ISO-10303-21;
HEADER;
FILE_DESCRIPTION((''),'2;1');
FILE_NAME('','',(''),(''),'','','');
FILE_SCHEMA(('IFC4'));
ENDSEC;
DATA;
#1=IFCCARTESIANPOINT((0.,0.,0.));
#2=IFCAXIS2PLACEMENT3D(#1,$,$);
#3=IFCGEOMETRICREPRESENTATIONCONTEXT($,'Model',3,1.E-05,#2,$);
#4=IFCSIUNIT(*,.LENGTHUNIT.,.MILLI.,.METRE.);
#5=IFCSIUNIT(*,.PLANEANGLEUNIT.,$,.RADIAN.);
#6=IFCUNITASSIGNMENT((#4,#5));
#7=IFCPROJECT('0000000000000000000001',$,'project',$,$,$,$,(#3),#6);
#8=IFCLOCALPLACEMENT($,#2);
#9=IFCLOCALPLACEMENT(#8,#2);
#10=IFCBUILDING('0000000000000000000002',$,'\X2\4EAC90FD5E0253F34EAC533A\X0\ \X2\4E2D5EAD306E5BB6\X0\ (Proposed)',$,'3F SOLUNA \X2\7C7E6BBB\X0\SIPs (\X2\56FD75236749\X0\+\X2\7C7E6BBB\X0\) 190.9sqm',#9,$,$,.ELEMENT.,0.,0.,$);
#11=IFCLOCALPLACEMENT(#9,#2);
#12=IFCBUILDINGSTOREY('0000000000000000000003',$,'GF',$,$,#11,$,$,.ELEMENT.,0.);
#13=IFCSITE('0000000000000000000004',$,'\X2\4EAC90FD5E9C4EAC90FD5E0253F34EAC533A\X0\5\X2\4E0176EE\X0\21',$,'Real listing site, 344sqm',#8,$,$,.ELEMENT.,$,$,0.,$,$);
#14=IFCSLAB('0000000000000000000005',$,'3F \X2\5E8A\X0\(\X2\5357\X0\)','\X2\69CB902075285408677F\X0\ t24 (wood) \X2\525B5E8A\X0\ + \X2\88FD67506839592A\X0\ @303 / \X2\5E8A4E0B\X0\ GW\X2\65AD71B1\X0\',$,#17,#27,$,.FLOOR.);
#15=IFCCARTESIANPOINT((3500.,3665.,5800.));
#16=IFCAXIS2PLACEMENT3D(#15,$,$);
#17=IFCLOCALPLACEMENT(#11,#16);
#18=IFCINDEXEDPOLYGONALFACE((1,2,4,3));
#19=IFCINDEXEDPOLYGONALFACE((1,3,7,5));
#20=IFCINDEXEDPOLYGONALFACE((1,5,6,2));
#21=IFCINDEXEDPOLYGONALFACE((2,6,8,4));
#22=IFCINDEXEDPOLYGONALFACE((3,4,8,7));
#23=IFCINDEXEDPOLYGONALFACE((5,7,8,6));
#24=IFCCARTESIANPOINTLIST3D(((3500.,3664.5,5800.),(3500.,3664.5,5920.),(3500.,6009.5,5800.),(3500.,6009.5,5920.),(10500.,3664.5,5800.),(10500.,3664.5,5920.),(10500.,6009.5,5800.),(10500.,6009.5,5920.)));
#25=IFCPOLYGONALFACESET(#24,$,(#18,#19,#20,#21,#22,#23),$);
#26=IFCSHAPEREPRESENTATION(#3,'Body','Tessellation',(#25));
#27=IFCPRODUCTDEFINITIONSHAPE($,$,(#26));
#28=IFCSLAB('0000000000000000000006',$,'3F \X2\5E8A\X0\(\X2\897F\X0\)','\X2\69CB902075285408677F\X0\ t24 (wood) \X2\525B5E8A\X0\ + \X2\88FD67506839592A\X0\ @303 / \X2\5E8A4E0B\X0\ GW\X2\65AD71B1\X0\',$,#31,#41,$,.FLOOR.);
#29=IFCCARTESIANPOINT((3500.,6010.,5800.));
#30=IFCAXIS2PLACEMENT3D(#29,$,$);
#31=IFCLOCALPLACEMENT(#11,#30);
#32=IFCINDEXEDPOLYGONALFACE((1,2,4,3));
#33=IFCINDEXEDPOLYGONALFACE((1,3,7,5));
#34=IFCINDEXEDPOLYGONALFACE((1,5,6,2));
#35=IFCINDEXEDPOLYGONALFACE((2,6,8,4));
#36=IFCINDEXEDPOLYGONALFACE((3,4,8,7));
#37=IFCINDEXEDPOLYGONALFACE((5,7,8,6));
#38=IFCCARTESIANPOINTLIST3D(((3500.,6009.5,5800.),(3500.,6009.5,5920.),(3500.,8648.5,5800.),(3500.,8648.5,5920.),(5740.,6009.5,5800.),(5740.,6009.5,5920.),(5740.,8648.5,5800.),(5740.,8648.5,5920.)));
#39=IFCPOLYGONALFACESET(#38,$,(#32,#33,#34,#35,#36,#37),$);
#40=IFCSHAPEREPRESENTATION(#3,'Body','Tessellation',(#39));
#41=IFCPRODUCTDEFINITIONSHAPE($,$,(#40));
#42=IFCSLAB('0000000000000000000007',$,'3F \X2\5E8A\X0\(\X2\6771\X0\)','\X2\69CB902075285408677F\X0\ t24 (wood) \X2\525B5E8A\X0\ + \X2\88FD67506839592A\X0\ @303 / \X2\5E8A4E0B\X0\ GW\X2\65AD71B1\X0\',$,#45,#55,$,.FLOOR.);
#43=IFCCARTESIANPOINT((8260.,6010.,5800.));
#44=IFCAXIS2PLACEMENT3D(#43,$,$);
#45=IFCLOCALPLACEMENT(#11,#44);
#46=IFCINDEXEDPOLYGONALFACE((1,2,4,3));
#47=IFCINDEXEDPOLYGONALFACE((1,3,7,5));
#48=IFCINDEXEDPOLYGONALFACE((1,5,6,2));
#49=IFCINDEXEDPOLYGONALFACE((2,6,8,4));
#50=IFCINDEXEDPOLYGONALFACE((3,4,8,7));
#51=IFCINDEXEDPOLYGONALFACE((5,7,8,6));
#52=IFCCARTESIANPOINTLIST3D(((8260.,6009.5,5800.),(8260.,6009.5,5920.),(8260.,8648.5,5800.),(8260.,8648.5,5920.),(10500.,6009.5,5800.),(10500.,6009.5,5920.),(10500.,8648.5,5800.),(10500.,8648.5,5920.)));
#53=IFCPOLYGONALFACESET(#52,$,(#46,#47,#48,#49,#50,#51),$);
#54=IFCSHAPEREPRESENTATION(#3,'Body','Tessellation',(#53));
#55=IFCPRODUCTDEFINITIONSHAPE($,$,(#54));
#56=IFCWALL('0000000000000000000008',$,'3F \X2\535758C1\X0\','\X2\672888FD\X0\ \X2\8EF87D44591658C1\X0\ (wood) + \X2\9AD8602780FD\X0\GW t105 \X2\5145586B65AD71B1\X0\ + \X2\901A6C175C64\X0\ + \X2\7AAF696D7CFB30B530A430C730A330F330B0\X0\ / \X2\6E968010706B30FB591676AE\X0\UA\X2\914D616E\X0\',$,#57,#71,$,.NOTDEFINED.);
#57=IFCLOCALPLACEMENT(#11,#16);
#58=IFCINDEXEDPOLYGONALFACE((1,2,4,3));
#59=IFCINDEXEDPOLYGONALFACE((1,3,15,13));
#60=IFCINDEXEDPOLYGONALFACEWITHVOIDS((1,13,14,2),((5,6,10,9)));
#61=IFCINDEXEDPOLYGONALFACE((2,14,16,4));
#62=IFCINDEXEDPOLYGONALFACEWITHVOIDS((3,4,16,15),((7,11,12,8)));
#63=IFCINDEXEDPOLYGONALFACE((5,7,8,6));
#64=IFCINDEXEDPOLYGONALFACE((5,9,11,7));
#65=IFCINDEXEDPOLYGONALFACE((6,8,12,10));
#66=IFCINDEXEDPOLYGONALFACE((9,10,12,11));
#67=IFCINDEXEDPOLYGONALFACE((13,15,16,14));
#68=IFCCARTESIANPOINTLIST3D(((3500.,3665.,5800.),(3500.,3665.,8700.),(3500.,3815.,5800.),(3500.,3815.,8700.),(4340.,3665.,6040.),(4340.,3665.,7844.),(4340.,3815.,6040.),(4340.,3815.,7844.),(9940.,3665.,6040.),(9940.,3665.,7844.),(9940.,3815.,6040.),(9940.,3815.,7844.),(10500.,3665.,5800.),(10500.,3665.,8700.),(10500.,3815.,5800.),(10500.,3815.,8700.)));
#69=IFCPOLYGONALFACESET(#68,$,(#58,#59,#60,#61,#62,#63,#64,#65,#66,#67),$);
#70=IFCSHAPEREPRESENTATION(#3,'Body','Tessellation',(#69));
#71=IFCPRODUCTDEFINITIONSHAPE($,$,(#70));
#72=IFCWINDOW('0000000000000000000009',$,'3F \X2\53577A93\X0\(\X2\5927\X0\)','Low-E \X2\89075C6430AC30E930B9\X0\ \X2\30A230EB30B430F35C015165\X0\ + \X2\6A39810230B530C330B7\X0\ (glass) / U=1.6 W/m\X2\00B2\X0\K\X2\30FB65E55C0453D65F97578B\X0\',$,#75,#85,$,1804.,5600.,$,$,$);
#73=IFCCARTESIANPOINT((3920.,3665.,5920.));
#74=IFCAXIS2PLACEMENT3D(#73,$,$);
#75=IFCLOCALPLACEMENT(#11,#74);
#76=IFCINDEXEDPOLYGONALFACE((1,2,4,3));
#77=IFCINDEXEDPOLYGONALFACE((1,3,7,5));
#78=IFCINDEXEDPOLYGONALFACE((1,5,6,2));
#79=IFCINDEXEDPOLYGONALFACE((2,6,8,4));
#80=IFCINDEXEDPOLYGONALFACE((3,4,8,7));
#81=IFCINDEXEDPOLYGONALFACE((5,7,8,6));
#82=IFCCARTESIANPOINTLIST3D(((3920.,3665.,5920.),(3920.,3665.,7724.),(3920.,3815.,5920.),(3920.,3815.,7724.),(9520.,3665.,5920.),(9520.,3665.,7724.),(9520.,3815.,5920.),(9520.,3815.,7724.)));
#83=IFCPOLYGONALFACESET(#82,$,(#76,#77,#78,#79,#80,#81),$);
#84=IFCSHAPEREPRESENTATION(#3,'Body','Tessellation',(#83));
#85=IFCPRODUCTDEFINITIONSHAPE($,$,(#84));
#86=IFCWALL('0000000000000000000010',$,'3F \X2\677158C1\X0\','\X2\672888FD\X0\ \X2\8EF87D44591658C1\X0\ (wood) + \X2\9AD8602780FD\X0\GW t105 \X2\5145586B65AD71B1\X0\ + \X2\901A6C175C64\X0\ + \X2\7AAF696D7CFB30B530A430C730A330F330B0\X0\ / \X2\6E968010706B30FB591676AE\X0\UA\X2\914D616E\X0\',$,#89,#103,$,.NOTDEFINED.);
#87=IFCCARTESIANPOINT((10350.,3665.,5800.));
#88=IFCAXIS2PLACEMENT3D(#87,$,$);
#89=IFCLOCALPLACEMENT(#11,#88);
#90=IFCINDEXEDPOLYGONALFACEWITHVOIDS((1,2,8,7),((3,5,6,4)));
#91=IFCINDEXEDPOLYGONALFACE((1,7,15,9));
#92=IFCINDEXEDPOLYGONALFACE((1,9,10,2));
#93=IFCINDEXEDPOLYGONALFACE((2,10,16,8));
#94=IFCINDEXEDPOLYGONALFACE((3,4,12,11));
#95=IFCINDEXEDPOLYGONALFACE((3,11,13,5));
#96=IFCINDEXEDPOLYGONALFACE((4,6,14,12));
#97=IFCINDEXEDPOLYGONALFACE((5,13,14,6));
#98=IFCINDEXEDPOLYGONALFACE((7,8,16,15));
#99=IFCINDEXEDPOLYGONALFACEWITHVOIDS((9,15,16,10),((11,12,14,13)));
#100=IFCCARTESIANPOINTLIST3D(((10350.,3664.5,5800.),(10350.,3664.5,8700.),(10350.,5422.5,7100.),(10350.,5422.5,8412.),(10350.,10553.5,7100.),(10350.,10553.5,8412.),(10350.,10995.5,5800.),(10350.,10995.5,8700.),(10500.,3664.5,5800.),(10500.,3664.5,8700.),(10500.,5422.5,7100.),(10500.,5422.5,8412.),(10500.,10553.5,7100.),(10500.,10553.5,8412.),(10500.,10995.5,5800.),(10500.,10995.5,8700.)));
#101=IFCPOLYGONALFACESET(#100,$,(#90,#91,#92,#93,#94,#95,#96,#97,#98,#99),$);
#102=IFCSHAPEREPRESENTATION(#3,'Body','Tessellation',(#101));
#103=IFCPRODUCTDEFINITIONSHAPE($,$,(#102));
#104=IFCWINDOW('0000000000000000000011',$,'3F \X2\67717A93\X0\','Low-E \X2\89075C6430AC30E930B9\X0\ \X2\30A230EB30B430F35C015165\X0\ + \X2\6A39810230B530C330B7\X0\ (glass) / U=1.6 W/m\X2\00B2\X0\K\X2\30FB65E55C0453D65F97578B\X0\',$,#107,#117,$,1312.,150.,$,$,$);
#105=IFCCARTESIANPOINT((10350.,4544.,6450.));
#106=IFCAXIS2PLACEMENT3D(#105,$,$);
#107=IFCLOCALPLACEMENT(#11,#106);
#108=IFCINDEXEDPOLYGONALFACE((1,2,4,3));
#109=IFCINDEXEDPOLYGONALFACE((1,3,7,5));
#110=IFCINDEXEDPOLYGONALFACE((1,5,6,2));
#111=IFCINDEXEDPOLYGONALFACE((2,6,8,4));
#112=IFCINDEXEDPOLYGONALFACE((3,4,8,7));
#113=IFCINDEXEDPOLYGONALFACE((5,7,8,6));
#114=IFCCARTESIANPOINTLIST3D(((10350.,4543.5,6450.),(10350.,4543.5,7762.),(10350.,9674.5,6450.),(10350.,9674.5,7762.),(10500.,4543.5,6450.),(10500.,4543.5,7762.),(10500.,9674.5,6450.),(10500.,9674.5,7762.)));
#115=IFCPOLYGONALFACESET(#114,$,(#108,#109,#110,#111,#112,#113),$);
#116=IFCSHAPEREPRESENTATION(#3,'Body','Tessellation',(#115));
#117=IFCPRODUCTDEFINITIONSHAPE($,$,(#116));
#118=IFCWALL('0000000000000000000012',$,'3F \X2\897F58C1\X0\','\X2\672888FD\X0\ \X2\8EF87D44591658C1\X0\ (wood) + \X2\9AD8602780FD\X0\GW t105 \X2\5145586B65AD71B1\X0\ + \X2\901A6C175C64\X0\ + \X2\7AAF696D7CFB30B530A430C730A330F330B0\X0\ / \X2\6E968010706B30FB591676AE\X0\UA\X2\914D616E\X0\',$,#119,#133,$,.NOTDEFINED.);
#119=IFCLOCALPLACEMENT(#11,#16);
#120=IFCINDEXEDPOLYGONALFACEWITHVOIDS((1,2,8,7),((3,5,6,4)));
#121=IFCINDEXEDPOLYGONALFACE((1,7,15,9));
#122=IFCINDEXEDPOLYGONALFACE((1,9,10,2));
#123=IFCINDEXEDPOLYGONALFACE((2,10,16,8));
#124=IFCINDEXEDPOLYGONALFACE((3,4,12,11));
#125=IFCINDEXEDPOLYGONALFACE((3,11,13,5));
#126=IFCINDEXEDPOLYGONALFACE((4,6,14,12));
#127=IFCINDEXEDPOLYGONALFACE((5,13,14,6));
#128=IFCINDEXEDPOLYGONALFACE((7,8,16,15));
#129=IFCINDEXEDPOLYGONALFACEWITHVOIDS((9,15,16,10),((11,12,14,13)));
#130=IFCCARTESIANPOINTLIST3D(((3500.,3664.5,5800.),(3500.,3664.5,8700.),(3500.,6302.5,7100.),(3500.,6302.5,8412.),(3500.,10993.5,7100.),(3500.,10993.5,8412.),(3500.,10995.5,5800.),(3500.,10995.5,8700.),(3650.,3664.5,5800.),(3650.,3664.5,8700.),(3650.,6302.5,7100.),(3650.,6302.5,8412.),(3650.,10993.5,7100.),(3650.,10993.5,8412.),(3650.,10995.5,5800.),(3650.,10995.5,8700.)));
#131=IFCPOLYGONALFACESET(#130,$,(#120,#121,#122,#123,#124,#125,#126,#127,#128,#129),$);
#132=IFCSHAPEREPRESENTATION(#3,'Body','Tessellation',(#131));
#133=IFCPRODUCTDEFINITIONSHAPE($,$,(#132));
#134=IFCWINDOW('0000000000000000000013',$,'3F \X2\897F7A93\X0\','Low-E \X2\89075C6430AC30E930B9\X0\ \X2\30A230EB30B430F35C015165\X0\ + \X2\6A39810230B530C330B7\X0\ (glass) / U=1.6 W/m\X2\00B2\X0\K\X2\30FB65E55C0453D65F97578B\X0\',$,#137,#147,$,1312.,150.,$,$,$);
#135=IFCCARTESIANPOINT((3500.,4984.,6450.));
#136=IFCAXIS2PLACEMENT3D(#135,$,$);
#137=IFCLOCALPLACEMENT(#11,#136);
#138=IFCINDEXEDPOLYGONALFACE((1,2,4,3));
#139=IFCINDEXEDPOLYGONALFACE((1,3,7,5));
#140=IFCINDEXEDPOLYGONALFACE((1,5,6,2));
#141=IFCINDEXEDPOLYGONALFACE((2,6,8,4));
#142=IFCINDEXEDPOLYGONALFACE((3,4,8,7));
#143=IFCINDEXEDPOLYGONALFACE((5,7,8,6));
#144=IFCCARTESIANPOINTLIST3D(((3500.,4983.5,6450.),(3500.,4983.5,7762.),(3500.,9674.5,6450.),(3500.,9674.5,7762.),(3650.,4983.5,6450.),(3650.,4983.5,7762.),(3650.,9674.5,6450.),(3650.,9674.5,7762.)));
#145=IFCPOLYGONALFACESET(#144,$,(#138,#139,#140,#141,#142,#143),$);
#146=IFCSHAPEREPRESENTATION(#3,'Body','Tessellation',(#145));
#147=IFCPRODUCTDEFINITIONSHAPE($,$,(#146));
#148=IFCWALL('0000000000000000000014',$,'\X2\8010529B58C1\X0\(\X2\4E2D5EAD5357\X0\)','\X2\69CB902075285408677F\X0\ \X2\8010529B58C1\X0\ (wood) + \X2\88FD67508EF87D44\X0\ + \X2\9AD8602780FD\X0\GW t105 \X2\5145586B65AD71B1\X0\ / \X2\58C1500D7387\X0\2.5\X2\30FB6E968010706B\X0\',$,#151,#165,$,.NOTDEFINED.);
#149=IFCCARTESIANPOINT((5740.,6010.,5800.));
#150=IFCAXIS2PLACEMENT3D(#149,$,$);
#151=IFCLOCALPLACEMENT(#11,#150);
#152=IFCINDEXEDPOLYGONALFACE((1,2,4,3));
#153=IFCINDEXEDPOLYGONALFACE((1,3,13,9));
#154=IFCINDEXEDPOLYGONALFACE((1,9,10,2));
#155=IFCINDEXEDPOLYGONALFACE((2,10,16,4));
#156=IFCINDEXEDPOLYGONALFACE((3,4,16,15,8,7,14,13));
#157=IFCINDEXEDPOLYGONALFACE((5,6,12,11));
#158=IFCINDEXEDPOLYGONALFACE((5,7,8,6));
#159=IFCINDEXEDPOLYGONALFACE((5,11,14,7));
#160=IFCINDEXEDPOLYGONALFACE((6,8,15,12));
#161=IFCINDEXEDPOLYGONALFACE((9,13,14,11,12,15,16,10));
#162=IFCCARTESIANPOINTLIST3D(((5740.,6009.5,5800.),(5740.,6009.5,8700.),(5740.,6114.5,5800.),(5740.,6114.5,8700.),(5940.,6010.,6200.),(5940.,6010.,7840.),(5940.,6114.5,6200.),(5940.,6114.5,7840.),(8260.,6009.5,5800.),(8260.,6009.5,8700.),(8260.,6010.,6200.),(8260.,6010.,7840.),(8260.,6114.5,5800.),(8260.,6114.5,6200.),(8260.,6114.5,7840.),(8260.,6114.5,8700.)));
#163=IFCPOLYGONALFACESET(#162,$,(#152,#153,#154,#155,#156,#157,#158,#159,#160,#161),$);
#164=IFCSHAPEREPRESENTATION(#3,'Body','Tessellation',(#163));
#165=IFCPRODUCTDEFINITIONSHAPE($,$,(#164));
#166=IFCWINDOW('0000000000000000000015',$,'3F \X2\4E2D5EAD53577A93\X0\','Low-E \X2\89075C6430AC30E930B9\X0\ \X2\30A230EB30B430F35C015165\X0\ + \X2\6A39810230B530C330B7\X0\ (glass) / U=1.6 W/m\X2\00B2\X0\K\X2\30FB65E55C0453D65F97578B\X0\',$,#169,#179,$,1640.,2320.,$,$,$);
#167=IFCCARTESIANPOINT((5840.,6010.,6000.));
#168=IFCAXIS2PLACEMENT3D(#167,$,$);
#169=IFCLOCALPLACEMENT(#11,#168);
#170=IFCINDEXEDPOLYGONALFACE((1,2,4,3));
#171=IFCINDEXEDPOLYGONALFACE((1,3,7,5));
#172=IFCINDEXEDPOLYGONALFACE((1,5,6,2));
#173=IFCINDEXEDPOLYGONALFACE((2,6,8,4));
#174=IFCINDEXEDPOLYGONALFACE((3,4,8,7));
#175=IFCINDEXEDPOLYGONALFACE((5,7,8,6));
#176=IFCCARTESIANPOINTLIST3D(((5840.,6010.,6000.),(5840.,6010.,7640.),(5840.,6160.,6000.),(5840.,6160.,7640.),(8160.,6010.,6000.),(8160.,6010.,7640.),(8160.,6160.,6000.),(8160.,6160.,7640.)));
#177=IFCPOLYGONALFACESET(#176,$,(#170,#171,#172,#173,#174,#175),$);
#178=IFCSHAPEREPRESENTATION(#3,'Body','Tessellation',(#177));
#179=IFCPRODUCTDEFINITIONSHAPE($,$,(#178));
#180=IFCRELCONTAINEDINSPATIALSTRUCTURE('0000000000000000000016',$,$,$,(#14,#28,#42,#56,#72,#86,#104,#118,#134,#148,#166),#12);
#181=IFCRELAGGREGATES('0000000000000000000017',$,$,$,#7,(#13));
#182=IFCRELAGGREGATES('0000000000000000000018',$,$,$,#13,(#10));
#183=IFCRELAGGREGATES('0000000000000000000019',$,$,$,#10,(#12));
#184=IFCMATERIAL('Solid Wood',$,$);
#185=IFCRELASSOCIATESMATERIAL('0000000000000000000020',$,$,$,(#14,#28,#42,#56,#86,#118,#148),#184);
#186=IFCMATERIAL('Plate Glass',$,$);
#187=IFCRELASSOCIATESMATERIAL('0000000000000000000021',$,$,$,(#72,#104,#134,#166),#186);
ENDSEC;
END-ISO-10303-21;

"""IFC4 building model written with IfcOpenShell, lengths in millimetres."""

from ifc_helpers import new_model, si_unit, frame, frame_2d, origin, place, context, project, spatial, rectangle, extrude, material, element, fill, save


model = new_model("IFC4")

# Units and contexts
model_context = context("Model", 3, precision=1e-05, world=origin())
ifc_project = project(units=[si_unit("LENGTHUNIT", "METRE", prefix="MILLI"), si_unit("PLANEANGLEUNIT", "RADIAN")], contexts=[model_context])

# Site, building, storey
site_placement = place(None, origin())
site = spatial("IfcSite", under=ifc_project, at=site_placement, Name="京都府京都市右京区5丁目21", ObjectType="Real listing site, 344sqm", CompositionType="ELEMENT", RefElevation=0.0)
building_placement = place(site_placement, origin())
building = spatial("IfcBuilding", under=site, at=building_placement, Name="京都市右京区 中庭の家 (Proposed)", ObjectType="3F SOLUNA 籾殻SIPs (国産杉+籾殻) 190.9sqm", CompositionType="ELEMENT", ElevationOfRefHeight=0.0, ElevationOfTerrain=0.0)
storey_placement = place(building_placement, origin())
storey = spatial("IfcBuildingStorey", under=building, at=storey_placement, Name="GF", CompositionType="ELEMENT", Elevation=0.0)

# Slabs
ifc_material_1 = material(Name="Solid Wood")
slab_1_placement = place(storey_placement, frame((3500.0, 3665.0, 5800.0)))
element("IfcSlab", 1, at=slab_1_placement, inside=storey, material=ifc_material_1, Name="3F 床(南)", Description="構造用合板 t24 (wood) 剛床 + 製材根太 @303 / 床下 GW断熱", PredefinedType="FLOOR", context=model_context, shape_type="SweptSolid", body=[
    extrude(rectangle(XDim=7000.0, YDim=2345.0, at=frame_2d((3500.0, 1172.0))), frame((3500.0, 3665.0, 5800.0)), (0.0, 0.0, 1.0), 120.0),
])
slab_2_placement = place(storey_placement, frame((3500.0, 6010.0, 5800.0)))
element("IfcSlab", 2, at=slab_2_placement, inside=storey, material=ifc_material_1, Name="3F 床(西)", Description="構造用合板 t24 (wood) 剛床 + 製材根太 @303 / 床下 GW断熱", PredefinedType="FLOOR", context=model_context, shape_type="SweptSolid", body=[
    extrude(rectangle(XDim=2240.0, YDim=2639.0, at=frame_2d((1120.0, 1319.0))), frame((3500.0, 6010.0, 5800.0)), (0.0, 0.0, 1.0), 120.0),
])
slab_3_placement = place(storey_placement, frame((8260.0, 6010.0, 5800.0)))
element("IfcSlab", 3, at=slab_3_placement, inside=storey, material=ifc_material_1, Name="3F 床(東)", Description="構造用合板 t24 (wood) 剛床 + 製材根太 @303 / 床下 GW断熱", PredefinedType="FLOOR", context=model_context, shape_type="SweptSolid", body=[
    extrude(rectangle(XDim=2240.0, YDim=2639.0, at=frame_2d((1120.0, 1319.0))), frame((8260.0, 6010.0, 5800.0)), (0.0, 0.0, 1.0), 120.0),
])

# Walls, openings, windows
wall_1_placement = place(storey_placement, frame((3500.0, 3665.0, 5800.0)))
wall_1 = element("IfcWall", 4, at=wall_1_placement, inside=storey, material=ifc_material_1, Name="3F 南壁", Description="木製 軸組外壁 (wood) + 高性能GW t105 充填断熱 + 通気層 + 窯業系サイディング / 準耐火・外皮UA配慮", PredefinedType="NOTDEFINED", context=model_context, shape_type="SweptSolid", body=[
    extrude(rectangle(XDim=7000.0, YDim=150.0, at=frame_2d((3500.0, 75.0))), frame((3500.0, 3665.0, 5800.0)), (0.0, 0.0, 1.0), 2900.0),
])
opening_1_placement = place(storey_placement, frame((3920.0, 3665.0, 5920.0)))
opening_1 = element("IfcOpeningElement", 5, at=opening_1_placement, cuts=wall_1, PredefinedType="NOTDEFINED", context=model_context, shape_type="SweptSolid", body=[
    extrude(rectangle(XDim=5600.0, YDim=150.0, at=frame_2d((2800.0, 75.0))), frame((3920.0, 3665.0, 5920.0)), (0.0, 0.0, 1.0), 1804.0),
])
ifc_material_2 = material(Name="Plate Glass")
window_1_placement = place(storey_placement, frame((3920.0, 3665.0, 5920.0)))
window_1 = element("IfcWindow", 6, at=window_1_placement, inside=storey, material=ifc_material_2, Name="3F 南窓(大)", Description="Low-E 複層ガラス アルゴン封入 + 樹脂サッシ (glass) / U=1.6 W/m²K・日射取得型", OverallHeight=1804.0, OverallWidth=5600.0, context=model_context, shape_type="SweptSolid", body=[
    extrude(rectangle(XDim=5600.0, YDim=150.0, at=frame_2d((2800.0, 75.0))), frame((3920.0, 3665.0, 5920.0)), (0.0, 0.0, 1.0), 1804.0),
])
fill(opening_1, window_1)
wall_2_placement = place(storey_placement, frame((10350.0, 3665.0, 5800.0)))
wall_2 = element("IfcWall", 7, at=wall_2_placement, inside=storey, material=ifc_material_1, Name="3F 東壁", Description="木製 軸組外壁 (wood) + 高性能GW t105 充填断熱 + 通気層 + 窯業系サイディング / 準耐火・外皮UA配慮", PredefinedType="NOTDEFINED", context=model_context, shape_type="SweptSolid", body=[
    extrude(rectangle(XDim=150.0, YDim=7331.0, at=frame_2d((75.0, 3665.0))), frame((10350.0, 3665.0, 5800.0)), (0.0, 0.0, 1.0), 2900.0),
])
opening_2_placement = place(storey_placement, frame((10350.0, 4544.0, 6450.0)))
opening_2 = element("IfcOpeningElement", 8, at=opening_2_placement, cuts=wall_2, PredefinedType="NOTDEFINED", context=model_context, shape_type="SweptSolid", body=[
    extrude(rectangle(XDim=150.0, YDim=5131.0, at=frame_2d((75.0, 2565.0))), frame((10350.0, 4544.0, 6450.0)), (0.0, 0.0, 1.0), 1312.0),
])
window_2_placement = place(storey_placement, frame((10350.0, 4544.0, 6450.0)))
window_2 = element("IfcWindow", 9, at=window_2_placement, inside=storey, material=ifc_material_2, Name="3F 東窓", Description="Low-E 複層ガラス アルゴン封入 + 樹脂サッシ (glass) / U=1.6 W/m²K・日射取得型", OverallHeight=1312.0, OverallWidth=150.0, context=model_context, shape_type="SweptSolid", body=[
    extrude(rectangle(XDim=150.0, YDim=5131.0, at=frame_2d((75.0, 2565.0))), frame((10350.0, 4544.0, 6450.0)), (0.0, 0.0, 1.0), 1312.0),
])
fill(opening_2, window_2)
wall_3_placement = place(storey_placement, frame((3500.0, 3665.0, 5800.0)))
wall_3 = element("IfcWall", 10, at=wall_3_placement, inside=storey, material=ifc_material_1, Name="3F 西壁", Description="木製 軸組外壁 (wood) + 高性能GW t105 充填断熱 + 通気層 + 窯業系サイディング / 準耐火・外皮UA配慮", PredefinedType="NOTDEFINED", context=model_context, shape_type="SweptSolid", body=[
    extrude(rectangle(XDim=150.0, YDim=7331.0, at=frame_2d((75.0, 3665.0))), frame((3500.0, 3665.0, 5800.0)), (0.0, 0.0, 1.0), 2900.0),
])
opening_3_placement = place(storey_placement, frame((3500.0, 4984.0, 6450.0)))
opening_3 = element("IfcOpeningElement", 11, at=opening_3_placement, cuts=wall_3, PredefinedType="NOTDEFINED", context=model_context, shape_type="SweptSolid", body=[
    extrude(rectangle(XDim=150.0, YDim=4691.0, at=frame_2d((75.0, 2345.0))), frame((3500.0, 4984.0, 6450.0)), (0.0, 0.0, 1.0), 1312.0),
])
window_3_placement = place(storey_placement, frame((3500.0, 4984.0, 6450.0)))
window_3 = element("IfcWindow", 12, at=window_3_placement, inside=storey, material=ifc_material_2, Name="3F 西窓", Description="Low-E 複層ガラス アルゴン封入 + 樹脂サッシ (glass) / U=1.6 W/m²K・日射取得型", OverallHeight=1312.0, OverallWidth=150.0, context=model_context, shape_type="SweptSolid", body=[
    extrude(rectangle(XDim=150.0, YDim=4691.0, at=frame_2d((75.0, 2345.0))), frame((3500.0, 4984.0, 6450.0)), (0.0, 0.0, 1.0), 1312.0),
])
fill(opening_3, window_3)
wall_4_placement = place(storey_placement, frame((5740.0, 6010.0, 5800.0)))
wall_4 = element("IfcWall", 13, at=wall_4_placement, inside=storey, material=ifc_material_1, Name="耐力壁(中庭南)", Description="構造用合板 耐力壁 (wood) + 製材軸組 + 高性能GW t105 充填断熱 / 壁倍率2.5・準耐火", PredefinedType="NOTDEFINED", context=model_context, shape_type="SweptSolid", body=[
    extrude(rectangle(XDim=2520.0, YDim=105.0, at=frame_2d((1260.0, 52.0))), frame((5740.0, 6010.0, 5800.0)), (0.0, 0.0, 1.0), 2900.0),
])
opening_4_placement = place(storey_placement, frame((5840.0, 6010.0, 6000.0)))
opening_4 = element("IfcOpeningElement", 14, at=opening_4_placement, cuts=wall_4, PredefinedType="NOTDEFINED", context=model_context, shape_type="SweptSolid", body=[
    extrude(rectangle(XDim=2320.0, YDim=150.0, at=frame_2d((1160.0, 75.0))), frame((5840.0, 6010.0, 6000.0)), (0.0, 0.0, 1.0), 1640.0),
])
window_4_placement = place(storey_placement, frame((5840.0, 6010.0, 6000.0)))
window_4 = element("IfcWindow", 15, at=window_4_placement, inside=storey, material=ifc_material_2, Name="3F 中庭南窓", Description="Low-E 複層ガラス アルゴン封入 + 樹脂サッシ (glass) / U=1.6 W/m²K・日射取得型", OverallHeight=1640.0, OverallWidth=2320.0, context=model_context, shape_type="SweptSolid", body=[
    extrude(rectangle(XDim=2320.0, YDim=150.0, at=frame_2d((1160.0, 75.0))), frame((5840.0, 6010.0, 6000.0)), (0.0, 0.0, 1.0), 1640.0),
])
fill(opening_4, window_4)

save(model, "model.ifc")
